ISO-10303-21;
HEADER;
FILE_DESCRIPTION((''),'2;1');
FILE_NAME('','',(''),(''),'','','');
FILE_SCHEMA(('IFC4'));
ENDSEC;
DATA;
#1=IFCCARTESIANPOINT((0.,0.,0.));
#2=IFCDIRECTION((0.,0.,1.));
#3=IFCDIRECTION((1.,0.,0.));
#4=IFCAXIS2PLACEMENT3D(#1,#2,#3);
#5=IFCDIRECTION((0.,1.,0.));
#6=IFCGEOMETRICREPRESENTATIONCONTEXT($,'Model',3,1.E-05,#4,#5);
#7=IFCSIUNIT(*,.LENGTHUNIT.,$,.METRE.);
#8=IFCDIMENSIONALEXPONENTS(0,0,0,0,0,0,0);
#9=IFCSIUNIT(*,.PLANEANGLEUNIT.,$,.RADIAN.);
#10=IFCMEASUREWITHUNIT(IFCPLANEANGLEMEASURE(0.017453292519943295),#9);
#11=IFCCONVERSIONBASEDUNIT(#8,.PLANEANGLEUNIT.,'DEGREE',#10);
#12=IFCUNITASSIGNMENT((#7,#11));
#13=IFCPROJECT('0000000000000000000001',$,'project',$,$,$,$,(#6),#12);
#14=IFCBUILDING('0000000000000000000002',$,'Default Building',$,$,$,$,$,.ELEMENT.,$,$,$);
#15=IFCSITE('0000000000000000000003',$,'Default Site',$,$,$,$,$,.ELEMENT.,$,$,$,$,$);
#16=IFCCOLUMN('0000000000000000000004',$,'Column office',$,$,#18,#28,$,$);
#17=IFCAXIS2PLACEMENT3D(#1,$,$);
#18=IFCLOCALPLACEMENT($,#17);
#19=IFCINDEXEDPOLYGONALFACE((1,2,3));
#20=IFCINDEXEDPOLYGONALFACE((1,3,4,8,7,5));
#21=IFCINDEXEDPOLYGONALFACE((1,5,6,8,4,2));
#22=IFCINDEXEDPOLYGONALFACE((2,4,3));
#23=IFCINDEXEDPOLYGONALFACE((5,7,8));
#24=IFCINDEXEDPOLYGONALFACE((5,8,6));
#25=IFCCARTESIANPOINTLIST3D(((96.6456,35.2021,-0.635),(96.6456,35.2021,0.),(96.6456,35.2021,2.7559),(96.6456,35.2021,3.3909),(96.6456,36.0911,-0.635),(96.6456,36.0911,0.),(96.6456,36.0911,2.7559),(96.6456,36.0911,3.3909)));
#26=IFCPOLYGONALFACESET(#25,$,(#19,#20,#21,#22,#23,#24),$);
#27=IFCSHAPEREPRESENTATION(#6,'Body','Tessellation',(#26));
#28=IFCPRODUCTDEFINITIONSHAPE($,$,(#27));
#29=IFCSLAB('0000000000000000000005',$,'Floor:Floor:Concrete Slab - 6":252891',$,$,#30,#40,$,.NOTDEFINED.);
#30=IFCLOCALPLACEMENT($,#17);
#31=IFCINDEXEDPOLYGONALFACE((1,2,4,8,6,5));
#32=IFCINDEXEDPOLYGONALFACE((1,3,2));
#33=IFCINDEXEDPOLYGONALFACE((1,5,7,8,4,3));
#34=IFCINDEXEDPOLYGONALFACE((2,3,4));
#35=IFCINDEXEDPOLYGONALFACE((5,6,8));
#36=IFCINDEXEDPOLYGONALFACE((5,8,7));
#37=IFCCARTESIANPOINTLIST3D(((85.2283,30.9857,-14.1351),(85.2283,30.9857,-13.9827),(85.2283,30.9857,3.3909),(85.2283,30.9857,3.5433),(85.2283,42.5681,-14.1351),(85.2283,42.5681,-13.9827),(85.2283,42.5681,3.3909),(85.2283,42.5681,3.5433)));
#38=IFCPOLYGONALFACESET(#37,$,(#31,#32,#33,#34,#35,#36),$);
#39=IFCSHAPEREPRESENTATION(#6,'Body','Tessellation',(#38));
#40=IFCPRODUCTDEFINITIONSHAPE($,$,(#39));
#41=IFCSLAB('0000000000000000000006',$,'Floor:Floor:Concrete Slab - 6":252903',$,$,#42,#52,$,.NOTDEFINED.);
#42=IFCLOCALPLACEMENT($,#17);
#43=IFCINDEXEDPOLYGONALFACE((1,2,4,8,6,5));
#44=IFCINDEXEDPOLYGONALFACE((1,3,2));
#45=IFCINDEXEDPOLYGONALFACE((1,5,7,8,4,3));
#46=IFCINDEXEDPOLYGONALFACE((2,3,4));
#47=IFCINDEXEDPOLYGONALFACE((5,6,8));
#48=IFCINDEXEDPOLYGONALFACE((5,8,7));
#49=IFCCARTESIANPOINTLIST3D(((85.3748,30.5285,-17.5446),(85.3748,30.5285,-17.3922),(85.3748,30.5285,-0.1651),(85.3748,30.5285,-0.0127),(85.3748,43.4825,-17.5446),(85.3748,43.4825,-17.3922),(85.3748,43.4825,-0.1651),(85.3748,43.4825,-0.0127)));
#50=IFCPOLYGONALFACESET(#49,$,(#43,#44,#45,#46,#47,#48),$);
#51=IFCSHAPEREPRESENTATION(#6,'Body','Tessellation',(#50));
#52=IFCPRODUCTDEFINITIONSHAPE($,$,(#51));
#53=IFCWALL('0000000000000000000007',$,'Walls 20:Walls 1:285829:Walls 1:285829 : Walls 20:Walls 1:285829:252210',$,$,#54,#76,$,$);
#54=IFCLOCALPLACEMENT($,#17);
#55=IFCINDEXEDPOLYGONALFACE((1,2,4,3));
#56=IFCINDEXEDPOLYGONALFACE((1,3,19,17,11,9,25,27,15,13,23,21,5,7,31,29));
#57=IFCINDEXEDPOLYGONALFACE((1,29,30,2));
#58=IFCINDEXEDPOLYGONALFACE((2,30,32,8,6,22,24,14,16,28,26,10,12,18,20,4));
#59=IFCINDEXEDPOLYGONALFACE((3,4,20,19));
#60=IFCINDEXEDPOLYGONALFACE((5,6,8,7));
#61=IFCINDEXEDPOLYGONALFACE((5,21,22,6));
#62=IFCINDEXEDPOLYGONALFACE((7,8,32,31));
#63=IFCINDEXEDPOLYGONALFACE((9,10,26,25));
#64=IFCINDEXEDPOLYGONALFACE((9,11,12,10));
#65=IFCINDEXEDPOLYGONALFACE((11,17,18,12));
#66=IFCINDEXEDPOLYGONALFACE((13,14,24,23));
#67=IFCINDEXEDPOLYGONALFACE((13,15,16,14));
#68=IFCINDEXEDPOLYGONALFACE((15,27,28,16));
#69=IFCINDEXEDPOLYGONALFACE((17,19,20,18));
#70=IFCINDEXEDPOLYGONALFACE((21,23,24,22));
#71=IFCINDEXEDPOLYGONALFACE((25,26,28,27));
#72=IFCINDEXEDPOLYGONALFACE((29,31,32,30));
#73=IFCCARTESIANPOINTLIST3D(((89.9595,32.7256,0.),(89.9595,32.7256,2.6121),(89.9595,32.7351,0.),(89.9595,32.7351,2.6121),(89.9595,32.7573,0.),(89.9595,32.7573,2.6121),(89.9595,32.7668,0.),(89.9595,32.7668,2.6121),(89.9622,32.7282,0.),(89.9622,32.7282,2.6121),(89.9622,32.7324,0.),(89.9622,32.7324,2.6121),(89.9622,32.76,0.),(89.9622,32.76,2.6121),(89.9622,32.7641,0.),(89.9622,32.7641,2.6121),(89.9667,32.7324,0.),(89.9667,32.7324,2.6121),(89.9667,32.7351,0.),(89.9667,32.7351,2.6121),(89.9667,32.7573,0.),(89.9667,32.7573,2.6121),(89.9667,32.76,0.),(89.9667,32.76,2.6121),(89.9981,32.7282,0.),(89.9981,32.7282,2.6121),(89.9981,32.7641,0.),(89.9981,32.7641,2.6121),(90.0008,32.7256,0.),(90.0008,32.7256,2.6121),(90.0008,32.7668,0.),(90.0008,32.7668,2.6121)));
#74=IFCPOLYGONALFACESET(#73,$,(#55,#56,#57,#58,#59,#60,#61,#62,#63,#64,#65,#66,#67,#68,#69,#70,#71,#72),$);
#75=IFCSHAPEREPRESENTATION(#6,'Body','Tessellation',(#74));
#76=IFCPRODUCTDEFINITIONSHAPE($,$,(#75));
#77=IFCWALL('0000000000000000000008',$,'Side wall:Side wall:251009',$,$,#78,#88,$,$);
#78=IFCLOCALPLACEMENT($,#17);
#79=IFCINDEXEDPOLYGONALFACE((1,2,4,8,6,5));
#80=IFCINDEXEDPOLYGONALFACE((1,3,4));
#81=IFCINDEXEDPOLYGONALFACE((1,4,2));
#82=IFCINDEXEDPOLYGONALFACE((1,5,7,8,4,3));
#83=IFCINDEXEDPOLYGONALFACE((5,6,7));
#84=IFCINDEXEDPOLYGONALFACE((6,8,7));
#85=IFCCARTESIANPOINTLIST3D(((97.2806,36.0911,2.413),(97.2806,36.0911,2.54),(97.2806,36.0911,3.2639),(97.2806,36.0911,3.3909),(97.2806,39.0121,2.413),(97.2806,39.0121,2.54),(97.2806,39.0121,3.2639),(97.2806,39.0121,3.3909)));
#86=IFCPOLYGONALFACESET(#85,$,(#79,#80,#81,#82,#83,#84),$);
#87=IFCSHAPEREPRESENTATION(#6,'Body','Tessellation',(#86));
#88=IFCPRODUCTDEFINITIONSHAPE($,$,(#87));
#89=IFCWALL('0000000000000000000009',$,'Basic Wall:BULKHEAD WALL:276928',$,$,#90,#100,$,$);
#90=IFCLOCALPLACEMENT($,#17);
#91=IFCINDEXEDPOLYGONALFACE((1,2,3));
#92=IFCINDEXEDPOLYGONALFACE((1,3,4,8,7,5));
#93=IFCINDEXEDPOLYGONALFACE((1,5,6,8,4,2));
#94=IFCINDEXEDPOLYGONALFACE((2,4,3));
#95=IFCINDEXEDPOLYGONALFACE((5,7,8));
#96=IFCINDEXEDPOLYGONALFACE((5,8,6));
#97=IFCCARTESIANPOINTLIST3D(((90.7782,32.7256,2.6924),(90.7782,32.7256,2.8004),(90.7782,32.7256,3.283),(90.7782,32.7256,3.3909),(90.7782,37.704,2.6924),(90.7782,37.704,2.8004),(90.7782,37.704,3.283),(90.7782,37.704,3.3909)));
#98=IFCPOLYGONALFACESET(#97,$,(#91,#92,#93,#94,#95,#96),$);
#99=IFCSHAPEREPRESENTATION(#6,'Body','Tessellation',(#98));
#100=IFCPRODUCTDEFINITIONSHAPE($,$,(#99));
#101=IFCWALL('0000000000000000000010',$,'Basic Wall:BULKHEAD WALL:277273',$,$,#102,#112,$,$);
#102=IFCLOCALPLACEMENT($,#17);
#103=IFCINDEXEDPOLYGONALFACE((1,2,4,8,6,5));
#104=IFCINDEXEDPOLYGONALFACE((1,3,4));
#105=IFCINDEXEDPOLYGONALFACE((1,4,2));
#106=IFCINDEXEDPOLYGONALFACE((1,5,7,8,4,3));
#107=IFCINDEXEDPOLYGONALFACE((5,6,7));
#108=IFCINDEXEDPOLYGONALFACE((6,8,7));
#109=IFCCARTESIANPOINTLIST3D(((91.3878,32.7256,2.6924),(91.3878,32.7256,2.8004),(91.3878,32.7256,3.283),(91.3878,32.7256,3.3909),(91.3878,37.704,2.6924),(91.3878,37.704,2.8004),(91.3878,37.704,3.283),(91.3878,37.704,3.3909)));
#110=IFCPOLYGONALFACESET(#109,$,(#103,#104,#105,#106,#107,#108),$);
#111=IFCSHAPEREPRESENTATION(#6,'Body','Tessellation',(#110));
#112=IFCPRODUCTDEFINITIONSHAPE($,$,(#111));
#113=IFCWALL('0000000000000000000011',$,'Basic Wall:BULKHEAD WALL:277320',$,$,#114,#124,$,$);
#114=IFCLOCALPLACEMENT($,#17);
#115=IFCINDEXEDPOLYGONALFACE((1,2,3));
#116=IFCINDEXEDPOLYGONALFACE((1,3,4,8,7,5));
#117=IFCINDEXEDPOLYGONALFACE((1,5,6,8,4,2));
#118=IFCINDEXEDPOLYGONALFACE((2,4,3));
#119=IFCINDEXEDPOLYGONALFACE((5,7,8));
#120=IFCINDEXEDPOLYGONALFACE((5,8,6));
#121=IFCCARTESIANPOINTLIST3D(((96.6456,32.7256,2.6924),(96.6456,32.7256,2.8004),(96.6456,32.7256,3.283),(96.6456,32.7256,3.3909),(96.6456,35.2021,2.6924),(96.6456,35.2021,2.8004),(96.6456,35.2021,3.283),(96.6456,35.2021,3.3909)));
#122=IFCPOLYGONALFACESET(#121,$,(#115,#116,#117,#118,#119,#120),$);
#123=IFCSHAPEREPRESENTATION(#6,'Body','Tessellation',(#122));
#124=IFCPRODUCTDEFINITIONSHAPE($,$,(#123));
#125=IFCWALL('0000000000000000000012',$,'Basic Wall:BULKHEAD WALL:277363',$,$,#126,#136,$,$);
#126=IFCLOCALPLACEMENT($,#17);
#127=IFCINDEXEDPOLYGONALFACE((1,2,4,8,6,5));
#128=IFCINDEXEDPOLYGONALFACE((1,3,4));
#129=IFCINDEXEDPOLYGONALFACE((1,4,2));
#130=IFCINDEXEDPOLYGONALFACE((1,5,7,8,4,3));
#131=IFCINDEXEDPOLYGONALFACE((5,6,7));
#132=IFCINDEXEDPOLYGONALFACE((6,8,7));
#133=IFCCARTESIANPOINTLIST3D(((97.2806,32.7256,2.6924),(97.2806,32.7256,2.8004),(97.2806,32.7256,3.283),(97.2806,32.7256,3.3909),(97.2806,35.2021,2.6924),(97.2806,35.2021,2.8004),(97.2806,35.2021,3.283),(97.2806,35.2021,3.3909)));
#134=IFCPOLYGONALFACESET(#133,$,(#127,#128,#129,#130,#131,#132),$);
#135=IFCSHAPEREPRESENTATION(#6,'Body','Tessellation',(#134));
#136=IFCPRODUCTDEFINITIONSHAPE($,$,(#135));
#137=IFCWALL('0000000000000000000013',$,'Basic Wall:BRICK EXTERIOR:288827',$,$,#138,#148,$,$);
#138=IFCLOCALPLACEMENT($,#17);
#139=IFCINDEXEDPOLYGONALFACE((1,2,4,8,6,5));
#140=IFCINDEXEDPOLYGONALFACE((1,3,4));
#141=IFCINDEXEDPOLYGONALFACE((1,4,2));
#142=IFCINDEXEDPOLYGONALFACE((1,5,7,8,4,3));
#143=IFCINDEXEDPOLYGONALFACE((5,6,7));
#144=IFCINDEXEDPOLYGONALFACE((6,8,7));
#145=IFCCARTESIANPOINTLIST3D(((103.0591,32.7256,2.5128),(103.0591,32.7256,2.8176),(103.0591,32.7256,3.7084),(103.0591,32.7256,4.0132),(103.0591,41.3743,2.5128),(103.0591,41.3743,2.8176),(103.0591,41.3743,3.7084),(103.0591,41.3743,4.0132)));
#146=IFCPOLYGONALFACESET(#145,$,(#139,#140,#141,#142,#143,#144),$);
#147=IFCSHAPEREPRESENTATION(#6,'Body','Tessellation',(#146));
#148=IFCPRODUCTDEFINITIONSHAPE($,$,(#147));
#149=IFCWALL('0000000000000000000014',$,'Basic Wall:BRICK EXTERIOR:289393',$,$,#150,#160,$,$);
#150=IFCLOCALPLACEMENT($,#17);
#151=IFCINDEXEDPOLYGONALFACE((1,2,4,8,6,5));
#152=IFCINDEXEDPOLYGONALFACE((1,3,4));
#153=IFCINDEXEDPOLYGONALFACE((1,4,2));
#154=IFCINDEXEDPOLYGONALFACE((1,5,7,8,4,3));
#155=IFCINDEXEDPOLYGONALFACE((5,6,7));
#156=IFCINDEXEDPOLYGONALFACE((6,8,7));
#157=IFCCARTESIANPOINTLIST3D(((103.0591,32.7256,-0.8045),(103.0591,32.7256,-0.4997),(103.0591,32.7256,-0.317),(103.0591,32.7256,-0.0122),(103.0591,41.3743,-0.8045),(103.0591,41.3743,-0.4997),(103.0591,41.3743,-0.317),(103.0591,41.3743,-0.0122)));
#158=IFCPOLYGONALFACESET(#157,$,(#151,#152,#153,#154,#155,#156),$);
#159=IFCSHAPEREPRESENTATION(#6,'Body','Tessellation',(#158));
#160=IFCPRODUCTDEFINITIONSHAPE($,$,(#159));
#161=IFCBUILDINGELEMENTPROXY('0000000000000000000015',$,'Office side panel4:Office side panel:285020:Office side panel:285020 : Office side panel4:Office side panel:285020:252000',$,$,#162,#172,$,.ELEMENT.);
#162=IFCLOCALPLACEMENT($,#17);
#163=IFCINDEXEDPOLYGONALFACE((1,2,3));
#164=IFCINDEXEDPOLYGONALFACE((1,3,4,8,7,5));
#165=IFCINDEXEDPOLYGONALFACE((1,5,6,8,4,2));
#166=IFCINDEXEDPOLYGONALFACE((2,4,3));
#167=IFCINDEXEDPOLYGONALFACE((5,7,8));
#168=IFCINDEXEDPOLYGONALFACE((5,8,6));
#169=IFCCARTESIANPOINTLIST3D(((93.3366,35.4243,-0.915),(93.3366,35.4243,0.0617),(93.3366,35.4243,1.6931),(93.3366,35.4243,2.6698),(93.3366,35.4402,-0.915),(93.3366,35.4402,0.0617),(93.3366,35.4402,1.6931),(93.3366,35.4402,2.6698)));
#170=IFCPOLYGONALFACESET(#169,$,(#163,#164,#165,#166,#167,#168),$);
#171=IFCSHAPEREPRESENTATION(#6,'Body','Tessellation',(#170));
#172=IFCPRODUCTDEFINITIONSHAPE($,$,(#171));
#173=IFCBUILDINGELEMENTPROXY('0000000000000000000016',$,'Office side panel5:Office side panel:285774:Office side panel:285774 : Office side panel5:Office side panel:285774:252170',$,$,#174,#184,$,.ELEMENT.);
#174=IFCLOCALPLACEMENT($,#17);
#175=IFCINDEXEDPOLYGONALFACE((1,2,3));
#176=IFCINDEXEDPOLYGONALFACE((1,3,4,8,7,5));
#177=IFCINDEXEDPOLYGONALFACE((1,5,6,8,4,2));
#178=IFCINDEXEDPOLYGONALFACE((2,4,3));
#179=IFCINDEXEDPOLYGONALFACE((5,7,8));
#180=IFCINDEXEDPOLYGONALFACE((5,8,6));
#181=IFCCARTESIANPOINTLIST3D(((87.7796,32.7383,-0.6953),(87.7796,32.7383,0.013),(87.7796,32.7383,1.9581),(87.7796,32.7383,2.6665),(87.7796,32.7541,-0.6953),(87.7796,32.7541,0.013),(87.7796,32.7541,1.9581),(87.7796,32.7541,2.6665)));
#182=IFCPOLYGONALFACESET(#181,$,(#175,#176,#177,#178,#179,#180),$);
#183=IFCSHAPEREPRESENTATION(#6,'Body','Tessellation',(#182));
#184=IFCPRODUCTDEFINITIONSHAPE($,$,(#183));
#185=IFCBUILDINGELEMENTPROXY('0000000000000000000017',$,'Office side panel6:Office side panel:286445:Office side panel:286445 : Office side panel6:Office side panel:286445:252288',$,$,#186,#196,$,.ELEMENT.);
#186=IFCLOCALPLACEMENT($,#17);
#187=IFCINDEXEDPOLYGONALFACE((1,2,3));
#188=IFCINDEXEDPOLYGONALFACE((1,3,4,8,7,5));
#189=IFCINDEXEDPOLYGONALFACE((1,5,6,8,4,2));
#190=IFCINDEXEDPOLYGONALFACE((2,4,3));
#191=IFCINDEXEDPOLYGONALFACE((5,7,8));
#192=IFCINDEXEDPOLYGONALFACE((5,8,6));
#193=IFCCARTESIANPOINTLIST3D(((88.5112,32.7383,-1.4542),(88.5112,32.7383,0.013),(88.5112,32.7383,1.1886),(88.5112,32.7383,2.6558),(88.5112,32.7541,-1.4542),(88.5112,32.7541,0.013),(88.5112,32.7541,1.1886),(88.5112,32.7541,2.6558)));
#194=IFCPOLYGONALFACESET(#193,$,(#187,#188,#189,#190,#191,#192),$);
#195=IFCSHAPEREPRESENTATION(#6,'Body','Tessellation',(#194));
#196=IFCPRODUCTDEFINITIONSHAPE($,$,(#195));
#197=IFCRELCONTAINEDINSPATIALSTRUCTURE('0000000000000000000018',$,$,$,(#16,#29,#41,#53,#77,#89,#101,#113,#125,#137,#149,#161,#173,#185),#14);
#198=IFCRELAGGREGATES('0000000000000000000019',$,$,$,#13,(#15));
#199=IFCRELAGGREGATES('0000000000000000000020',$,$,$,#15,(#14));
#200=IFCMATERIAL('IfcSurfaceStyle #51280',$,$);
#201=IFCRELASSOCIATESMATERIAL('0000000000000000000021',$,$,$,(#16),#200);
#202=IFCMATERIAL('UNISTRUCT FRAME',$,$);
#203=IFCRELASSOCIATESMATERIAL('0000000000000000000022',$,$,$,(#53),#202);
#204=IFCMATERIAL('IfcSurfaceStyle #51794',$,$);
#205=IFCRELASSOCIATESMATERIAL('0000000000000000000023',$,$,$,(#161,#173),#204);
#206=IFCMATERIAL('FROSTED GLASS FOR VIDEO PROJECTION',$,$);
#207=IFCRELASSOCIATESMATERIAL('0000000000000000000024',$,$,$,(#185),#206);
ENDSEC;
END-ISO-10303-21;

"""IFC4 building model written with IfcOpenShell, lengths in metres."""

from ifc_helpers import new_model, entity, si_unit, converted_unit, direction, frame, origin_with_axes, place, context, project, spatial, polyline, outline, extrude, material, element, save


model = new_model("IFC4")

# Units and contexts
model_context = context("Model", 3, precision=1e-05, world=origin_with_axes(), true_north=direction((0.0, 1.0, 0.0)))
ifc_project = project(units=[si_unit("LENGTHUNIT", "METRE"), converted_unit("PLANEANGLEUNIT", "DEGREE", entity("IfcPlaneAngleMeasure", 0.017453292519943295), si_unit("PLANEANGLEUNIT", "RADIAN"), dimensions=[0, 0, 0, 0, 0, 0, 0])], contexts=[model_context])

# Site, building
site = spatial("IfcSite", under=ifc_project, Name="Default Site", CompositionType="ELEMENT")
building = spatial("IfcBuilding", under=site, Name="Default Building", CompositionType="ELEMENT")

# Column
ifc_material_1 = material(Name="IfcSurfaceStyle #51280")
column_placement = place(None, origin_with_axes())
element("IfcColumn", 1, at=column_placement, inside=building, material=ifc_material_1, Name="Column office", context=model_context, shape_type="SweptSolid", body=[
    extrude(outline(polyline([(1.6954, 0.4445), (-1.6954, 0.4445), (-1.6954, -0.4445), (1.6954, -0.4445), (1.6954, 0.4445)])), frame((96.6456, 35.6466, 1.6954), z_axis=(1.0, 0.0, 0.0), x_axis=(0.0, 0.0, -1.0)), (1.0, 0.0, 0.0), 0.635),
])

# Slabs
slab_1_placement = place(None, origin_with_axes())
element("IfcSlab", 2, at=slab_1_placement, inside=building, Name="Floor:Floor:Concrete Slab - 6\":252891", PredefinedType="NOTDEFINED", context=model_context, shape_type="SweptSolid", body=[
    extrude(outline(polyline([(-0.0762, -5.7912), (0.0762, -5.7912), (0.0762, 5.7912), (-0.0762, 5.7912), (-0.0762, -5.7912)])), frame((85.2283, 36.7769, 3.4671), z_axis=(1.0, 0.0, 0.0), x_axis=(0.0, 0.0, -1.0)), (1.0, 0.0, 0.0), 17.526),
])
slab_2_placement = place(None, origin_with_axes())
element("IfcSlab", 3, at=slab_2_placement, inside=building, Name="Floor:Floor:Concrete Slab - 6\":252903", PredefinedType="NOTDEFINED", context=model_context, shape_type="SweptSolid", body=[
    extrude(outline(polyline([(-0.0762, -6.477), (0.0762, -6.477), (0.0762, 6.477), (-0.0762, 6.477), (-0.0762, -6.477)])), frame((85.3748, 37.0055, -0.0889), z_axis=(1.0, 0.0, 0.0), x_axis=(0.0, 0.0, -1.0)), (1.0, 0.0, 0.0), 17.3795),
])

# Walls
ifc_material_2 = material(Name="UNISTRUCT FRAME")
wall_1_placement = place(None, origin_with_axes())
element("IfcWall", 4, at=wall_1_placement, inside=building, material=ifc_material_2, Name="Walls 20:Walls 1:285829:Walls 1:285829 : Walls 20:Walls 1:285829:252210", context=model_context, shape_type="SweptSolid", body=[
    extrude(outline(polyline([(89.9595, 32.7668), (89.9595, 32.7573), (89.9667, 32.7573), (89.9667, 32.76), (89.9622, 32.76), (89.9622, 32.7641), (89.9981, 32.7641), (89.9981, 32.7282), (89.9622, 32.7282), (89.9622, 32.7324), (89.9667, 32.7324), (89.9667, 32.7351), (89.9595, 32.7351), (89.9595, 32.7256), (90.0008, 32.7256), (90.0008, 32.7668), (89.9595, 32.7668)])), origin_with_axes(), (0.0, 0.0, 1.0), 2.6121),
])
wall_2_placement = place(None, origin_with_axes())
element("IfcWall", 5, at=wall_2_placement, inside=building, Name="Side wall:Side wall:251009", context=model_context, shape_type="SweptSolid", body=[
    extrude(outline(polyline([(-0.4254, -1.4605), (0.4254, -1.4605), (0.4254, 1.4605), (-0.4254, 1.4605), (-0.4254, -1.4605)])), frame((97.2806, 37.5516, 2.9655), z_axis=(-1.0, 0.0, 0.0), x_axis=(0.0, 0.0, 1.0)), (-1.0, 0.0, 0.0), 0.127),
])
wall_3_placement = place(None, origin_with_axes())
element("IfcWall", 6, at=wall_3_placement, inside=building, Name="Basic Wall:BULKHEAD WALL:276928", context=model_context, shape_type="SweptSolid", body=[
    extrude(outline(polyline([(0.2953, 2.4892), (-0.2953, 2.4892), (-0.2953, -2.4892), (0.2953, -2.4892), (0.2953, 2.4892)])), frame((90.7782, 35.2148, 3.0956), z_axis=(1.0, 0.0, 0.0), x_axis=(0.0, 0.0, -1.0)), (1.0, 0.0, 0.0), 0.1079),
])
wall_4_placement = place(None, origin_with_axes())
element("IfcWall", 7, at=wall_4_placement, inside=building, Name="Basic Wall:BULKHEAD WALL:277273", context=model_context, shape_type="SweptSolid", body=[
    extrude(outline(polyline([(-0.2953, -2.4892), (0.2953, -2.4892), (0.2953, 2.4892), (-0.2953, 2.4892), (-0.2953, -2.4892)])), frame((91.3878, 35.2148, 3.0956), z_axis=(-1.0, 0.0, 0.0), x_axis=(0.0, 0.0, 1.0)), (-1.0, 0.0, 0.0), 0.1079),
])
wall_5_placement = place(None, origin_with_axes())
element("IfcWall", 8, at=wall_5_placement, inside=building, Name="Basic Wall:BULKHEAD WALL:277320", context=model_context, shape_type="SweptSolid", body=[
    extrude(outline(polyline([(0.2953, 1.2383), (-0.2953, 1.2383), (-0.2953, -1.2383), (0.2953, -1.2383), (0.2953, 1.2383)])), frame((96.6456, 33.9638, 3.0956), z_axis=(1.0, 0.0, 0.0), x_axis=(0.0, 0.0, -1.0)), (1.0, 0.0, 0.0), 0.1079),
])
wall_6_placement = place(None, origin_with_axes())
element("IfcWall", 9, at=wall_6_placement, inside=building, Name="Basic Wall:BULKHEAD WALL:277363", context=model_context, shape_type="SweptSolid", body=[
    extrude(outline(polyline([(-0.2953, -1.2383), (0.2953, -1.2383), (0.2953, 1.2383), (-0.2953, 1.2383), (-0.2953, -1.2383)])), frame((97.2806, 33.9638, 3.0956), z_axis=(-1.0, 0.0, 0.0), x_axis=(0.0, 0.0, 1.0)), (-1.0, 0.0, 0.0), 0.1079),
])
wall_7_placement = place(None, origin_with_axes())
element("IfcWall", 10, at=wall_7_placement, inside=building, Name="Basic Wall:BRICK EXTERIOR:288827", context=model_context, shape_type="SweptSolid", body=[
    extrude(outline(polyline([(-0.5978, -4.3243), (0.5978, -4.3243), (0.5978, 4.3243), (-0.5978, 4.3243), (-0.5978, -4.3243)])), frame((103.0591, 37.0499, 3.4154), z_axis=(-1.0, 0.0, 0.0), x_axis=(0.0, 0.0, 1.0)), (-1.0, 0.0, 0.0), 0.3048),
])
wall_8_placement = place(None, origin_with_axes())
element("IfcWall", 11, at=wall_8_placement, inside=building, Name="Basic Wall:BRICK EXTERIOR:289393", context=model_context, shape_type="SweptSolid", body=[
    extrude(outline(polyline([(-0.2437, -4.3243), (0.2437, -4.3243), (0.2437, 4.3243), (-0.2437, 4.3243), (-0.2437, -4.3243)])), frame((103.0591, 37.0499, -0.256), z_axis=(-1.0, 0.0, 0.0), x_axis=(0.0, 0.0, 1.0)), (-1.0, 0.0, 0.0), 0.3048),
])

# Building element proxies
ifc_material_3 = material(Name="IfcSurfaceStyle #51794")
proxy_1_placement = place(None, origin_with_axes())
element("IfcBuildingElementProxy", 12, at=proxy_1_placement, inside=building, material=ifc_material_3, Name="Office side panel4:Office side panel:285020:Office side panel:285020 : Office side panel4:Office side panel:285020:252000", PredefinedType="ELEMENT", context=model_context, shape_type="SweptSolid", body=[
    extrude(outline(polyline([(1.304, 0.0079), (-1.304, 0.0079), (-1.304, -0.0079), (1.304, -0.0079), (1.304, 0.0079)])), frame((93.3366, 35.4322, 1.3658), z_axis=(1.0, 0.0, 0.0), x_axis=(0.0, 0.0, -1.0)), (1.0, 0.0, 0.0), 0.9767),
])
proxy_2_placement = place(None, origin_with_axes())
element("IfcBuildingElementProxy", 13, at=proxy_2_placement, inside=building, material=ifc_material_3, Name="Office side panel5:Office side panel:285774:Office side panel:285774 : Office side panel5:Office side panel:285774:252170", PredefinedType="ELEMENT", context=model_context, shape_type="SweptSolid", body=[
    extrude(outline(polyline([(1.3267, 0.0079), (-1.3267, 0.0079), (-1.3267, -0.0079), (1.3267, -0.0079), (1.3267, 0.0079)])), frame((87.7796, 32.7462, 1.3398), z_axis=(1.0, 0.0, 0.0), x_axis=(0.0, 0.0, -1.0)), (1.0, 0.0, 0.0), 0.7084),
])
ifc_material_4 = material(Name="FROSTED GLASS FOR VIDEO PROJECTION")
proxy_3_placement = place(None, origin_with_axes())
element("IfcBuildingElementProxy", 14, at=proxy_3_placement, inside=building, material=ifc_material_4, Name="Office side panel6:Office side panel:286445:Office side panel:286445 : Office side panel6:Office side panel:286445:252288", PredefinedType="ELEMENT", context=model_context, shape_type="SweptSolid", body=[
    extrude(outline(polyline([(1.3214, 0.0079), (-1.3214, 0.0079), (-1.3214, -0.0079), (1.3214, -0.0079), (1.3214, 0.0079)])), frame((88.5112, 32.7462, 1.3344), z_axis=(1.0, 0.0, 0.0), x_axis=(0.0, 0.0, -1.0)), (1.0, 0.0, 0.0), 1.4672),
])

save(model, "model.ifc")
